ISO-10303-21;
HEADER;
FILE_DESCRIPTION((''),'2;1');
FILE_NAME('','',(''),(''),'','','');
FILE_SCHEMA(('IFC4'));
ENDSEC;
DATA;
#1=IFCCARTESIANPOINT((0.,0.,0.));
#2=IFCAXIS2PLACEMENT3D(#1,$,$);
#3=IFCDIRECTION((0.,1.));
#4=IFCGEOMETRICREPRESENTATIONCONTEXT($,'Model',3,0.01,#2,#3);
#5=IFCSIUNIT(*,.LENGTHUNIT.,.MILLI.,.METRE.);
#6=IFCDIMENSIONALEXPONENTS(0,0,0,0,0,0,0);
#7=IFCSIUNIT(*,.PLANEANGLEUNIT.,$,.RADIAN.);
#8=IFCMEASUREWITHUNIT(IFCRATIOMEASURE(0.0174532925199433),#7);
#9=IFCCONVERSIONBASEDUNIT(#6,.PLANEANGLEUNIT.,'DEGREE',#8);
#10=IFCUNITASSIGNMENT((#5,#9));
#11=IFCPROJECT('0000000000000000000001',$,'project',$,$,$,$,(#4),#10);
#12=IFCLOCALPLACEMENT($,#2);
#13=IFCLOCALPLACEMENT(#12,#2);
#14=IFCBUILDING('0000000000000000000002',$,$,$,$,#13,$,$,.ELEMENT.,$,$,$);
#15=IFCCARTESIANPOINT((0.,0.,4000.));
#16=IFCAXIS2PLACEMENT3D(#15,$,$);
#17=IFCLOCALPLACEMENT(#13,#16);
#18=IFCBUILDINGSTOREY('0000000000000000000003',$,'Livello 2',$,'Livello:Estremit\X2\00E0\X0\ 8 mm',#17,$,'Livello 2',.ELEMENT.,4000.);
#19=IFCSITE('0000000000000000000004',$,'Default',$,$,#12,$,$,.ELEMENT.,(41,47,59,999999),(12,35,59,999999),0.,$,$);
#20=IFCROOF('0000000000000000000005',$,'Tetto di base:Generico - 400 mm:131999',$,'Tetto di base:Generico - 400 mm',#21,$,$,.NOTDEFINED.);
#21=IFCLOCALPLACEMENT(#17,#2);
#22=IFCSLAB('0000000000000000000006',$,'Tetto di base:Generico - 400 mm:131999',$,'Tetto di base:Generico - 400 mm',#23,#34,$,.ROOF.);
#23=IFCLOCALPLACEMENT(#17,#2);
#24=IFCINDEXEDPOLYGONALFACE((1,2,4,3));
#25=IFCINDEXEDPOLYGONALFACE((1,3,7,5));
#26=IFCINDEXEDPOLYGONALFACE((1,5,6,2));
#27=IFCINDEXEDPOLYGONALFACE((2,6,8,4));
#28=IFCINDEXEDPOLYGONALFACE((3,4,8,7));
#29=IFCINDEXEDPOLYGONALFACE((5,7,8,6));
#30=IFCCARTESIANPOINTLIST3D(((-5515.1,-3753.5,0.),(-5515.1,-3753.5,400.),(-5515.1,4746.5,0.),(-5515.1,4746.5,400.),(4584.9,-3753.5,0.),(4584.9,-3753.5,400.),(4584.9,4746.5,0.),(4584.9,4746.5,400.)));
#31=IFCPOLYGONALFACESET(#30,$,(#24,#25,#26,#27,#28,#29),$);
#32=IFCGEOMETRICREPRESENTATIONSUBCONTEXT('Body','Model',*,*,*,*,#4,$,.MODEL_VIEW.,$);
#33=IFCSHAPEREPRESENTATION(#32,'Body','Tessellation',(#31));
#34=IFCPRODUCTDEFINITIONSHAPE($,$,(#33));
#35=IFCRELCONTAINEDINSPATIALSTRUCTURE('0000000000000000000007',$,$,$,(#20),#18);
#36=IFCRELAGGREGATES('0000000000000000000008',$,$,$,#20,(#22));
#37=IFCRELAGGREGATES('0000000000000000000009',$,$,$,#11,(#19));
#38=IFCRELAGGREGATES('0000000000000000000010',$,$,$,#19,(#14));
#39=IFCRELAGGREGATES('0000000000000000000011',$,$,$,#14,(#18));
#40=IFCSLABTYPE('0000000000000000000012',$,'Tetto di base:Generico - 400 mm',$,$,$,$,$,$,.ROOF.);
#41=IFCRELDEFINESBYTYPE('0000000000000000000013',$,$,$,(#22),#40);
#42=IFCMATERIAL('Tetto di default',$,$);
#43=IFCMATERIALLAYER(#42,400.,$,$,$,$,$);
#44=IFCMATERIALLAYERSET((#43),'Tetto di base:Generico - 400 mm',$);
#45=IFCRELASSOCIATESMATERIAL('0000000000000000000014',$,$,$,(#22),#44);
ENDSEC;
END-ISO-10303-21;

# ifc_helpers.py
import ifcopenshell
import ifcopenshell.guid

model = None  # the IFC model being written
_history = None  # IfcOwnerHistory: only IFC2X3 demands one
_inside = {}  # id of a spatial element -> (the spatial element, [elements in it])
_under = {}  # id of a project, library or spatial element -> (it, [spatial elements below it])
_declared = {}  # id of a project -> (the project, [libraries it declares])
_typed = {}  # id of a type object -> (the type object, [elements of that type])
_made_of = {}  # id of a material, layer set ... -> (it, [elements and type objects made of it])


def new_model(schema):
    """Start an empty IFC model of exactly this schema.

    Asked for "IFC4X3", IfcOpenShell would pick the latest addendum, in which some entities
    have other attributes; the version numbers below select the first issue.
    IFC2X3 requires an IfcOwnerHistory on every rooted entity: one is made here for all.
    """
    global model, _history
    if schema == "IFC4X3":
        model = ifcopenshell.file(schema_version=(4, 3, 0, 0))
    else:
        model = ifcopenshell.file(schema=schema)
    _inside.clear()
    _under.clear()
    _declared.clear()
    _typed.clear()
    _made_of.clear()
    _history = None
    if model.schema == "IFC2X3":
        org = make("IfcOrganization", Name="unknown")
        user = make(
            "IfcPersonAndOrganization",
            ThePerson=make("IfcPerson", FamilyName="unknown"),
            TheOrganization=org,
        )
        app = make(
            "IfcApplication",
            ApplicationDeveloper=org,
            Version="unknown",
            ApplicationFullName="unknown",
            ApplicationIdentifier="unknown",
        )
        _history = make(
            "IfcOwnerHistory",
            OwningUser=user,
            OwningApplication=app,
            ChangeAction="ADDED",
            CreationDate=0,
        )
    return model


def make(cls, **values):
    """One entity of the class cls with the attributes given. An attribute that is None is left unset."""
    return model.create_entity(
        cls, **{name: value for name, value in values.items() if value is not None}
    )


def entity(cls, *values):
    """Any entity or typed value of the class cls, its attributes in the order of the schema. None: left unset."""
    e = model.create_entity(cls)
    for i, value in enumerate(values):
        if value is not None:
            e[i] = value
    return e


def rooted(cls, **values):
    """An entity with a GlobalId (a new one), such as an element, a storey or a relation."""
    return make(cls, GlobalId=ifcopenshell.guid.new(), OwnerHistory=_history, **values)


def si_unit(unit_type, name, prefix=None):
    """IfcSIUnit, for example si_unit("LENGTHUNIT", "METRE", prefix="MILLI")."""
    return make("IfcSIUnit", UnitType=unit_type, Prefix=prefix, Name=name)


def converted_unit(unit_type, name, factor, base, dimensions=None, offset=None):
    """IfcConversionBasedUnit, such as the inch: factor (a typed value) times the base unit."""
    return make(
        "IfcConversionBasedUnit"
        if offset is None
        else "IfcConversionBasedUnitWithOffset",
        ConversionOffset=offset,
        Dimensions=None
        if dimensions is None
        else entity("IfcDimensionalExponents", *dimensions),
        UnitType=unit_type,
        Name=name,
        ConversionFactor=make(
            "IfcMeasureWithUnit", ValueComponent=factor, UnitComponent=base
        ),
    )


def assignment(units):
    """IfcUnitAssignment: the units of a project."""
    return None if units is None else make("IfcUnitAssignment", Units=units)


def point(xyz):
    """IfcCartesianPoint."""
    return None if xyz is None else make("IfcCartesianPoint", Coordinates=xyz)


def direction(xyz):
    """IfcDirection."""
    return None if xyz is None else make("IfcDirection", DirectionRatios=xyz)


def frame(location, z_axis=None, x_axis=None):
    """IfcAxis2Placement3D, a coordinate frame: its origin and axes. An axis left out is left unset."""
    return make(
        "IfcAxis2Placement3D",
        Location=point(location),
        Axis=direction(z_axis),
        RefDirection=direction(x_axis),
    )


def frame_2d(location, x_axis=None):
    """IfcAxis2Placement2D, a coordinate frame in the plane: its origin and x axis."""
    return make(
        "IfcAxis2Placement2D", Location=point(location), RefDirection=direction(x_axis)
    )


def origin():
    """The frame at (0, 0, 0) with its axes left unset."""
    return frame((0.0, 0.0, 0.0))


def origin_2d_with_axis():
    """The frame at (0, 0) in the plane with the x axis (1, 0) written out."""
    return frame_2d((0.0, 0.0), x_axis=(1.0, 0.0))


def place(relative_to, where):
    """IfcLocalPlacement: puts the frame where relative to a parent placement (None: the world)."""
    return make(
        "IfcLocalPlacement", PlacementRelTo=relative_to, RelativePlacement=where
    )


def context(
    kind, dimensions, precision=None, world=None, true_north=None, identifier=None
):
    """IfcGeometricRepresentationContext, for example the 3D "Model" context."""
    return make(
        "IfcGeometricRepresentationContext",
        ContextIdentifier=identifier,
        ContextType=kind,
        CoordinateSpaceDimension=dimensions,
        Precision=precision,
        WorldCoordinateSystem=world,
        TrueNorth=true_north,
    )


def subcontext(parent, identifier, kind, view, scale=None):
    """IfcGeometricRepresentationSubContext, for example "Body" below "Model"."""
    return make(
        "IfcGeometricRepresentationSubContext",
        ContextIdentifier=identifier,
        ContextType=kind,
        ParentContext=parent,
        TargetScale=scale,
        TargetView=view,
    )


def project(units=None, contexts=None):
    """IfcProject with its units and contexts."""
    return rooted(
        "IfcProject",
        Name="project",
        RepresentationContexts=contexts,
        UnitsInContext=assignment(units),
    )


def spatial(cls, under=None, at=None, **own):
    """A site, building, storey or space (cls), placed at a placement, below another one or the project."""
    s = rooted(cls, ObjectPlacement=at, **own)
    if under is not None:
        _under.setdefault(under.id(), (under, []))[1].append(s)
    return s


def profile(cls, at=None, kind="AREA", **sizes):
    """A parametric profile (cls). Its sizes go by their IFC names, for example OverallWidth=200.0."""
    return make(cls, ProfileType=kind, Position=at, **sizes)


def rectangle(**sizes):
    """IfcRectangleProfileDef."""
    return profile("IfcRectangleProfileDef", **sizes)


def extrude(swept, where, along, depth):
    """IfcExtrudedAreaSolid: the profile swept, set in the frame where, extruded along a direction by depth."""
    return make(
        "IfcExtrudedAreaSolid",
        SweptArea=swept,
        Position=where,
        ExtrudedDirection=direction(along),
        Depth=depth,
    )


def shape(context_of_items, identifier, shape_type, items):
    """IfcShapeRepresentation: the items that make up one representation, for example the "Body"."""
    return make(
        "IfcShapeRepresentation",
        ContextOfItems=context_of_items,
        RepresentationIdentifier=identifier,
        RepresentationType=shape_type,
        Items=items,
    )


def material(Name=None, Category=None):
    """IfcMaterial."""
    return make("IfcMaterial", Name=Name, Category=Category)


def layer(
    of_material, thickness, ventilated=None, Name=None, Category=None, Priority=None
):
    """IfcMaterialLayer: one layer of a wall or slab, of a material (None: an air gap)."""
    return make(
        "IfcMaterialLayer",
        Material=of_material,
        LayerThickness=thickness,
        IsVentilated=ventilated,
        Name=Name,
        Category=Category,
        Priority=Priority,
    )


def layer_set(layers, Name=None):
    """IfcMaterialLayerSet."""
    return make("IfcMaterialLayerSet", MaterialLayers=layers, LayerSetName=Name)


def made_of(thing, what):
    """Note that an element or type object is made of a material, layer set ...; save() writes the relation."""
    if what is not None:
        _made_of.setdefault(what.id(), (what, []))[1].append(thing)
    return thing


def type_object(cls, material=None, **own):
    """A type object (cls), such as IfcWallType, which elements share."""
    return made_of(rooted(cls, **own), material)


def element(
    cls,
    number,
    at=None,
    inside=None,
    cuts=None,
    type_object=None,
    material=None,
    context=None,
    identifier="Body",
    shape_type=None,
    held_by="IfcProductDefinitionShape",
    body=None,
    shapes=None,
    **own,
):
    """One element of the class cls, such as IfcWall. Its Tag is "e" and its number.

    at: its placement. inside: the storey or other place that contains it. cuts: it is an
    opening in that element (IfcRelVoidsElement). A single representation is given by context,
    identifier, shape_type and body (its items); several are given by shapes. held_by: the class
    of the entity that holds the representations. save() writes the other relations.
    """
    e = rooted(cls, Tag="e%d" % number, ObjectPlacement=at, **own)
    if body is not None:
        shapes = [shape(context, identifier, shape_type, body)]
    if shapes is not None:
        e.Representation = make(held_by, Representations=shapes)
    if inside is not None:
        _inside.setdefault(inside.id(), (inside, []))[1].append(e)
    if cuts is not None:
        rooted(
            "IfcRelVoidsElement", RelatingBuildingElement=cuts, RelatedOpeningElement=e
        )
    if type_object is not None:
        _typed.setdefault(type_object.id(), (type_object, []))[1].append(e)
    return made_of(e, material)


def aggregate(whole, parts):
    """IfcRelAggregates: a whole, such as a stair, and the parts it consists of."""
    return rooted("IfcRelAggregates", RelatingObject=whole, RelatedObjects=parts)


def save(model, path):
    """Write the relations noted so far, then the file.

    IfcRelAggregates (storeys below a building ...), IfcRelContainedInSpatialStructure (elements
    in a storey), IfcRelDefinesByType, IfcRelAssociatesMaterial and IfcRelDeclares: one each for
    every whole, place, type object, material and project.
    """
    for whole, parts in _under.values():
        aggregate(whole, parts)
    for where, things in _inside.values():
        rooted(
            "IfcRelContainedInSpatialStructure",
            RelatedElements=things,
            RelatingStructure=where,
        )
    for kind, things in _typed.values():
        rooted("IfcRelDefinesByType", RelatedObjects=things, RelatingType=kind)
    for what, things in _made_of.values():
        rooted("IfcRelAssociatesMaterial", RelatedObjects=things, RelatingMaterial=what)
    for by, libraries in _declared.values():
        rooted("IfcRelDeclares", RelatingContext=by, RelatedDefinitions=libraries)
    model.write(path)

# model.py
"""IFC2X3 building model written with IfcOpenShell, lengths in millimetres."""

from ifc_helpers import new_model, entity, si_unit, converted_unit, direction, frame, origin, origin_2d_with_axis, place, context, subcontext, project, spatial, rectangle, extrude, material, layer, layer_set, type_object, element, aggregate, save


model = new_model("IFC2X3")

# Units and contexts
model_context = context("Model", 3, precision=0.01, world=origin(), true_north=direction((0.0, 1.0)))
body_context = subcontext(model_context, "Body", "Model", "MODEL_VIEW")
ifc_project = project(units=[si_unit("LENGTHUNIT", "METRE", prefix="MILLI"), converted_unit("PLANEANGLEUNIT", "DEGREE", entity("IfcRatioMeasure", 0.0174532925199433), si_unit("PLANEANGLEUNIT", "RADIAN"), dimensions=[0, 0, 0, 0, 0, 0, 0])], contexts=[model_context])

# Site, building, storey
site_placement = place(None, origin())
site = spatial("IfcSite", under=ifc_project, at=site_placement, Name="Default", CompositionType="ELEMENT", RefLatitude=(41, 47, 59, 999999), RefLongitude=(12, 35, 59, 999999), RefElevation=0.0)
building_placement = place(site_placement, origin())
building = spatial("IfcBuilding", under=site, at=building_placement, CompositionType="ELEMENT")
storey_placement = place(building_placement, frame((0.0, 0.0, 4000.0)))
storey = spatial("IfcBuildingStorey", under=building, at=storey_placement, Name="Livello 2", ObjectType="Livello:Estremità 8 mm", LongName="Livello 2", CompositionType="ELEMENT", Elevation=4000.0)

# Roof, slab
roof_placement = place(storey_placement, frame((-5515.1, -3753.5, 0.0)))
roof = element("IfcRoof", 1, at=roof_placement, inside=storey, Name="Tetto di base:Generico - 400 mm:131999", ObjectType="Tetto di base:Generico - 400 mm", ShapeType="NOTDEFINED")
ifc_material = material(Name="Tetto di default")
ifc_layer = layer(ifc_material, 400.0)
ifc_layer_set = layer_set([ifc_layer], Name="Tetto di base:Generico - 400 mm")
slab_type = type_object("IfcSlabType", Name="Tetto di base:Generico - 400 mm", PredefinedType="ROOF")
slab_placement = place(roof_placement, origin())
slab = element("IfcSlab", 2, at=slab_placement, type_object=slab_type, material=ifc_layer_set, Name="Tetto di base:Generico - 400 mm:131999", ObjectType="Tetto di base:Generico - 400 mm", PredefinedType="ROOF", context=body_context, shape_type="SweptSolid", body=[
    extrude(rectangle(XDim=10100.0, YDim=8500.0, at=origin_2d_with_axis()), frame((5050.0, 4250.0, 0.0)), (0.0, 0.0, 1.0), 400.0),
])
aggregate(roof, [slab])

save(model, "model.ifc")
